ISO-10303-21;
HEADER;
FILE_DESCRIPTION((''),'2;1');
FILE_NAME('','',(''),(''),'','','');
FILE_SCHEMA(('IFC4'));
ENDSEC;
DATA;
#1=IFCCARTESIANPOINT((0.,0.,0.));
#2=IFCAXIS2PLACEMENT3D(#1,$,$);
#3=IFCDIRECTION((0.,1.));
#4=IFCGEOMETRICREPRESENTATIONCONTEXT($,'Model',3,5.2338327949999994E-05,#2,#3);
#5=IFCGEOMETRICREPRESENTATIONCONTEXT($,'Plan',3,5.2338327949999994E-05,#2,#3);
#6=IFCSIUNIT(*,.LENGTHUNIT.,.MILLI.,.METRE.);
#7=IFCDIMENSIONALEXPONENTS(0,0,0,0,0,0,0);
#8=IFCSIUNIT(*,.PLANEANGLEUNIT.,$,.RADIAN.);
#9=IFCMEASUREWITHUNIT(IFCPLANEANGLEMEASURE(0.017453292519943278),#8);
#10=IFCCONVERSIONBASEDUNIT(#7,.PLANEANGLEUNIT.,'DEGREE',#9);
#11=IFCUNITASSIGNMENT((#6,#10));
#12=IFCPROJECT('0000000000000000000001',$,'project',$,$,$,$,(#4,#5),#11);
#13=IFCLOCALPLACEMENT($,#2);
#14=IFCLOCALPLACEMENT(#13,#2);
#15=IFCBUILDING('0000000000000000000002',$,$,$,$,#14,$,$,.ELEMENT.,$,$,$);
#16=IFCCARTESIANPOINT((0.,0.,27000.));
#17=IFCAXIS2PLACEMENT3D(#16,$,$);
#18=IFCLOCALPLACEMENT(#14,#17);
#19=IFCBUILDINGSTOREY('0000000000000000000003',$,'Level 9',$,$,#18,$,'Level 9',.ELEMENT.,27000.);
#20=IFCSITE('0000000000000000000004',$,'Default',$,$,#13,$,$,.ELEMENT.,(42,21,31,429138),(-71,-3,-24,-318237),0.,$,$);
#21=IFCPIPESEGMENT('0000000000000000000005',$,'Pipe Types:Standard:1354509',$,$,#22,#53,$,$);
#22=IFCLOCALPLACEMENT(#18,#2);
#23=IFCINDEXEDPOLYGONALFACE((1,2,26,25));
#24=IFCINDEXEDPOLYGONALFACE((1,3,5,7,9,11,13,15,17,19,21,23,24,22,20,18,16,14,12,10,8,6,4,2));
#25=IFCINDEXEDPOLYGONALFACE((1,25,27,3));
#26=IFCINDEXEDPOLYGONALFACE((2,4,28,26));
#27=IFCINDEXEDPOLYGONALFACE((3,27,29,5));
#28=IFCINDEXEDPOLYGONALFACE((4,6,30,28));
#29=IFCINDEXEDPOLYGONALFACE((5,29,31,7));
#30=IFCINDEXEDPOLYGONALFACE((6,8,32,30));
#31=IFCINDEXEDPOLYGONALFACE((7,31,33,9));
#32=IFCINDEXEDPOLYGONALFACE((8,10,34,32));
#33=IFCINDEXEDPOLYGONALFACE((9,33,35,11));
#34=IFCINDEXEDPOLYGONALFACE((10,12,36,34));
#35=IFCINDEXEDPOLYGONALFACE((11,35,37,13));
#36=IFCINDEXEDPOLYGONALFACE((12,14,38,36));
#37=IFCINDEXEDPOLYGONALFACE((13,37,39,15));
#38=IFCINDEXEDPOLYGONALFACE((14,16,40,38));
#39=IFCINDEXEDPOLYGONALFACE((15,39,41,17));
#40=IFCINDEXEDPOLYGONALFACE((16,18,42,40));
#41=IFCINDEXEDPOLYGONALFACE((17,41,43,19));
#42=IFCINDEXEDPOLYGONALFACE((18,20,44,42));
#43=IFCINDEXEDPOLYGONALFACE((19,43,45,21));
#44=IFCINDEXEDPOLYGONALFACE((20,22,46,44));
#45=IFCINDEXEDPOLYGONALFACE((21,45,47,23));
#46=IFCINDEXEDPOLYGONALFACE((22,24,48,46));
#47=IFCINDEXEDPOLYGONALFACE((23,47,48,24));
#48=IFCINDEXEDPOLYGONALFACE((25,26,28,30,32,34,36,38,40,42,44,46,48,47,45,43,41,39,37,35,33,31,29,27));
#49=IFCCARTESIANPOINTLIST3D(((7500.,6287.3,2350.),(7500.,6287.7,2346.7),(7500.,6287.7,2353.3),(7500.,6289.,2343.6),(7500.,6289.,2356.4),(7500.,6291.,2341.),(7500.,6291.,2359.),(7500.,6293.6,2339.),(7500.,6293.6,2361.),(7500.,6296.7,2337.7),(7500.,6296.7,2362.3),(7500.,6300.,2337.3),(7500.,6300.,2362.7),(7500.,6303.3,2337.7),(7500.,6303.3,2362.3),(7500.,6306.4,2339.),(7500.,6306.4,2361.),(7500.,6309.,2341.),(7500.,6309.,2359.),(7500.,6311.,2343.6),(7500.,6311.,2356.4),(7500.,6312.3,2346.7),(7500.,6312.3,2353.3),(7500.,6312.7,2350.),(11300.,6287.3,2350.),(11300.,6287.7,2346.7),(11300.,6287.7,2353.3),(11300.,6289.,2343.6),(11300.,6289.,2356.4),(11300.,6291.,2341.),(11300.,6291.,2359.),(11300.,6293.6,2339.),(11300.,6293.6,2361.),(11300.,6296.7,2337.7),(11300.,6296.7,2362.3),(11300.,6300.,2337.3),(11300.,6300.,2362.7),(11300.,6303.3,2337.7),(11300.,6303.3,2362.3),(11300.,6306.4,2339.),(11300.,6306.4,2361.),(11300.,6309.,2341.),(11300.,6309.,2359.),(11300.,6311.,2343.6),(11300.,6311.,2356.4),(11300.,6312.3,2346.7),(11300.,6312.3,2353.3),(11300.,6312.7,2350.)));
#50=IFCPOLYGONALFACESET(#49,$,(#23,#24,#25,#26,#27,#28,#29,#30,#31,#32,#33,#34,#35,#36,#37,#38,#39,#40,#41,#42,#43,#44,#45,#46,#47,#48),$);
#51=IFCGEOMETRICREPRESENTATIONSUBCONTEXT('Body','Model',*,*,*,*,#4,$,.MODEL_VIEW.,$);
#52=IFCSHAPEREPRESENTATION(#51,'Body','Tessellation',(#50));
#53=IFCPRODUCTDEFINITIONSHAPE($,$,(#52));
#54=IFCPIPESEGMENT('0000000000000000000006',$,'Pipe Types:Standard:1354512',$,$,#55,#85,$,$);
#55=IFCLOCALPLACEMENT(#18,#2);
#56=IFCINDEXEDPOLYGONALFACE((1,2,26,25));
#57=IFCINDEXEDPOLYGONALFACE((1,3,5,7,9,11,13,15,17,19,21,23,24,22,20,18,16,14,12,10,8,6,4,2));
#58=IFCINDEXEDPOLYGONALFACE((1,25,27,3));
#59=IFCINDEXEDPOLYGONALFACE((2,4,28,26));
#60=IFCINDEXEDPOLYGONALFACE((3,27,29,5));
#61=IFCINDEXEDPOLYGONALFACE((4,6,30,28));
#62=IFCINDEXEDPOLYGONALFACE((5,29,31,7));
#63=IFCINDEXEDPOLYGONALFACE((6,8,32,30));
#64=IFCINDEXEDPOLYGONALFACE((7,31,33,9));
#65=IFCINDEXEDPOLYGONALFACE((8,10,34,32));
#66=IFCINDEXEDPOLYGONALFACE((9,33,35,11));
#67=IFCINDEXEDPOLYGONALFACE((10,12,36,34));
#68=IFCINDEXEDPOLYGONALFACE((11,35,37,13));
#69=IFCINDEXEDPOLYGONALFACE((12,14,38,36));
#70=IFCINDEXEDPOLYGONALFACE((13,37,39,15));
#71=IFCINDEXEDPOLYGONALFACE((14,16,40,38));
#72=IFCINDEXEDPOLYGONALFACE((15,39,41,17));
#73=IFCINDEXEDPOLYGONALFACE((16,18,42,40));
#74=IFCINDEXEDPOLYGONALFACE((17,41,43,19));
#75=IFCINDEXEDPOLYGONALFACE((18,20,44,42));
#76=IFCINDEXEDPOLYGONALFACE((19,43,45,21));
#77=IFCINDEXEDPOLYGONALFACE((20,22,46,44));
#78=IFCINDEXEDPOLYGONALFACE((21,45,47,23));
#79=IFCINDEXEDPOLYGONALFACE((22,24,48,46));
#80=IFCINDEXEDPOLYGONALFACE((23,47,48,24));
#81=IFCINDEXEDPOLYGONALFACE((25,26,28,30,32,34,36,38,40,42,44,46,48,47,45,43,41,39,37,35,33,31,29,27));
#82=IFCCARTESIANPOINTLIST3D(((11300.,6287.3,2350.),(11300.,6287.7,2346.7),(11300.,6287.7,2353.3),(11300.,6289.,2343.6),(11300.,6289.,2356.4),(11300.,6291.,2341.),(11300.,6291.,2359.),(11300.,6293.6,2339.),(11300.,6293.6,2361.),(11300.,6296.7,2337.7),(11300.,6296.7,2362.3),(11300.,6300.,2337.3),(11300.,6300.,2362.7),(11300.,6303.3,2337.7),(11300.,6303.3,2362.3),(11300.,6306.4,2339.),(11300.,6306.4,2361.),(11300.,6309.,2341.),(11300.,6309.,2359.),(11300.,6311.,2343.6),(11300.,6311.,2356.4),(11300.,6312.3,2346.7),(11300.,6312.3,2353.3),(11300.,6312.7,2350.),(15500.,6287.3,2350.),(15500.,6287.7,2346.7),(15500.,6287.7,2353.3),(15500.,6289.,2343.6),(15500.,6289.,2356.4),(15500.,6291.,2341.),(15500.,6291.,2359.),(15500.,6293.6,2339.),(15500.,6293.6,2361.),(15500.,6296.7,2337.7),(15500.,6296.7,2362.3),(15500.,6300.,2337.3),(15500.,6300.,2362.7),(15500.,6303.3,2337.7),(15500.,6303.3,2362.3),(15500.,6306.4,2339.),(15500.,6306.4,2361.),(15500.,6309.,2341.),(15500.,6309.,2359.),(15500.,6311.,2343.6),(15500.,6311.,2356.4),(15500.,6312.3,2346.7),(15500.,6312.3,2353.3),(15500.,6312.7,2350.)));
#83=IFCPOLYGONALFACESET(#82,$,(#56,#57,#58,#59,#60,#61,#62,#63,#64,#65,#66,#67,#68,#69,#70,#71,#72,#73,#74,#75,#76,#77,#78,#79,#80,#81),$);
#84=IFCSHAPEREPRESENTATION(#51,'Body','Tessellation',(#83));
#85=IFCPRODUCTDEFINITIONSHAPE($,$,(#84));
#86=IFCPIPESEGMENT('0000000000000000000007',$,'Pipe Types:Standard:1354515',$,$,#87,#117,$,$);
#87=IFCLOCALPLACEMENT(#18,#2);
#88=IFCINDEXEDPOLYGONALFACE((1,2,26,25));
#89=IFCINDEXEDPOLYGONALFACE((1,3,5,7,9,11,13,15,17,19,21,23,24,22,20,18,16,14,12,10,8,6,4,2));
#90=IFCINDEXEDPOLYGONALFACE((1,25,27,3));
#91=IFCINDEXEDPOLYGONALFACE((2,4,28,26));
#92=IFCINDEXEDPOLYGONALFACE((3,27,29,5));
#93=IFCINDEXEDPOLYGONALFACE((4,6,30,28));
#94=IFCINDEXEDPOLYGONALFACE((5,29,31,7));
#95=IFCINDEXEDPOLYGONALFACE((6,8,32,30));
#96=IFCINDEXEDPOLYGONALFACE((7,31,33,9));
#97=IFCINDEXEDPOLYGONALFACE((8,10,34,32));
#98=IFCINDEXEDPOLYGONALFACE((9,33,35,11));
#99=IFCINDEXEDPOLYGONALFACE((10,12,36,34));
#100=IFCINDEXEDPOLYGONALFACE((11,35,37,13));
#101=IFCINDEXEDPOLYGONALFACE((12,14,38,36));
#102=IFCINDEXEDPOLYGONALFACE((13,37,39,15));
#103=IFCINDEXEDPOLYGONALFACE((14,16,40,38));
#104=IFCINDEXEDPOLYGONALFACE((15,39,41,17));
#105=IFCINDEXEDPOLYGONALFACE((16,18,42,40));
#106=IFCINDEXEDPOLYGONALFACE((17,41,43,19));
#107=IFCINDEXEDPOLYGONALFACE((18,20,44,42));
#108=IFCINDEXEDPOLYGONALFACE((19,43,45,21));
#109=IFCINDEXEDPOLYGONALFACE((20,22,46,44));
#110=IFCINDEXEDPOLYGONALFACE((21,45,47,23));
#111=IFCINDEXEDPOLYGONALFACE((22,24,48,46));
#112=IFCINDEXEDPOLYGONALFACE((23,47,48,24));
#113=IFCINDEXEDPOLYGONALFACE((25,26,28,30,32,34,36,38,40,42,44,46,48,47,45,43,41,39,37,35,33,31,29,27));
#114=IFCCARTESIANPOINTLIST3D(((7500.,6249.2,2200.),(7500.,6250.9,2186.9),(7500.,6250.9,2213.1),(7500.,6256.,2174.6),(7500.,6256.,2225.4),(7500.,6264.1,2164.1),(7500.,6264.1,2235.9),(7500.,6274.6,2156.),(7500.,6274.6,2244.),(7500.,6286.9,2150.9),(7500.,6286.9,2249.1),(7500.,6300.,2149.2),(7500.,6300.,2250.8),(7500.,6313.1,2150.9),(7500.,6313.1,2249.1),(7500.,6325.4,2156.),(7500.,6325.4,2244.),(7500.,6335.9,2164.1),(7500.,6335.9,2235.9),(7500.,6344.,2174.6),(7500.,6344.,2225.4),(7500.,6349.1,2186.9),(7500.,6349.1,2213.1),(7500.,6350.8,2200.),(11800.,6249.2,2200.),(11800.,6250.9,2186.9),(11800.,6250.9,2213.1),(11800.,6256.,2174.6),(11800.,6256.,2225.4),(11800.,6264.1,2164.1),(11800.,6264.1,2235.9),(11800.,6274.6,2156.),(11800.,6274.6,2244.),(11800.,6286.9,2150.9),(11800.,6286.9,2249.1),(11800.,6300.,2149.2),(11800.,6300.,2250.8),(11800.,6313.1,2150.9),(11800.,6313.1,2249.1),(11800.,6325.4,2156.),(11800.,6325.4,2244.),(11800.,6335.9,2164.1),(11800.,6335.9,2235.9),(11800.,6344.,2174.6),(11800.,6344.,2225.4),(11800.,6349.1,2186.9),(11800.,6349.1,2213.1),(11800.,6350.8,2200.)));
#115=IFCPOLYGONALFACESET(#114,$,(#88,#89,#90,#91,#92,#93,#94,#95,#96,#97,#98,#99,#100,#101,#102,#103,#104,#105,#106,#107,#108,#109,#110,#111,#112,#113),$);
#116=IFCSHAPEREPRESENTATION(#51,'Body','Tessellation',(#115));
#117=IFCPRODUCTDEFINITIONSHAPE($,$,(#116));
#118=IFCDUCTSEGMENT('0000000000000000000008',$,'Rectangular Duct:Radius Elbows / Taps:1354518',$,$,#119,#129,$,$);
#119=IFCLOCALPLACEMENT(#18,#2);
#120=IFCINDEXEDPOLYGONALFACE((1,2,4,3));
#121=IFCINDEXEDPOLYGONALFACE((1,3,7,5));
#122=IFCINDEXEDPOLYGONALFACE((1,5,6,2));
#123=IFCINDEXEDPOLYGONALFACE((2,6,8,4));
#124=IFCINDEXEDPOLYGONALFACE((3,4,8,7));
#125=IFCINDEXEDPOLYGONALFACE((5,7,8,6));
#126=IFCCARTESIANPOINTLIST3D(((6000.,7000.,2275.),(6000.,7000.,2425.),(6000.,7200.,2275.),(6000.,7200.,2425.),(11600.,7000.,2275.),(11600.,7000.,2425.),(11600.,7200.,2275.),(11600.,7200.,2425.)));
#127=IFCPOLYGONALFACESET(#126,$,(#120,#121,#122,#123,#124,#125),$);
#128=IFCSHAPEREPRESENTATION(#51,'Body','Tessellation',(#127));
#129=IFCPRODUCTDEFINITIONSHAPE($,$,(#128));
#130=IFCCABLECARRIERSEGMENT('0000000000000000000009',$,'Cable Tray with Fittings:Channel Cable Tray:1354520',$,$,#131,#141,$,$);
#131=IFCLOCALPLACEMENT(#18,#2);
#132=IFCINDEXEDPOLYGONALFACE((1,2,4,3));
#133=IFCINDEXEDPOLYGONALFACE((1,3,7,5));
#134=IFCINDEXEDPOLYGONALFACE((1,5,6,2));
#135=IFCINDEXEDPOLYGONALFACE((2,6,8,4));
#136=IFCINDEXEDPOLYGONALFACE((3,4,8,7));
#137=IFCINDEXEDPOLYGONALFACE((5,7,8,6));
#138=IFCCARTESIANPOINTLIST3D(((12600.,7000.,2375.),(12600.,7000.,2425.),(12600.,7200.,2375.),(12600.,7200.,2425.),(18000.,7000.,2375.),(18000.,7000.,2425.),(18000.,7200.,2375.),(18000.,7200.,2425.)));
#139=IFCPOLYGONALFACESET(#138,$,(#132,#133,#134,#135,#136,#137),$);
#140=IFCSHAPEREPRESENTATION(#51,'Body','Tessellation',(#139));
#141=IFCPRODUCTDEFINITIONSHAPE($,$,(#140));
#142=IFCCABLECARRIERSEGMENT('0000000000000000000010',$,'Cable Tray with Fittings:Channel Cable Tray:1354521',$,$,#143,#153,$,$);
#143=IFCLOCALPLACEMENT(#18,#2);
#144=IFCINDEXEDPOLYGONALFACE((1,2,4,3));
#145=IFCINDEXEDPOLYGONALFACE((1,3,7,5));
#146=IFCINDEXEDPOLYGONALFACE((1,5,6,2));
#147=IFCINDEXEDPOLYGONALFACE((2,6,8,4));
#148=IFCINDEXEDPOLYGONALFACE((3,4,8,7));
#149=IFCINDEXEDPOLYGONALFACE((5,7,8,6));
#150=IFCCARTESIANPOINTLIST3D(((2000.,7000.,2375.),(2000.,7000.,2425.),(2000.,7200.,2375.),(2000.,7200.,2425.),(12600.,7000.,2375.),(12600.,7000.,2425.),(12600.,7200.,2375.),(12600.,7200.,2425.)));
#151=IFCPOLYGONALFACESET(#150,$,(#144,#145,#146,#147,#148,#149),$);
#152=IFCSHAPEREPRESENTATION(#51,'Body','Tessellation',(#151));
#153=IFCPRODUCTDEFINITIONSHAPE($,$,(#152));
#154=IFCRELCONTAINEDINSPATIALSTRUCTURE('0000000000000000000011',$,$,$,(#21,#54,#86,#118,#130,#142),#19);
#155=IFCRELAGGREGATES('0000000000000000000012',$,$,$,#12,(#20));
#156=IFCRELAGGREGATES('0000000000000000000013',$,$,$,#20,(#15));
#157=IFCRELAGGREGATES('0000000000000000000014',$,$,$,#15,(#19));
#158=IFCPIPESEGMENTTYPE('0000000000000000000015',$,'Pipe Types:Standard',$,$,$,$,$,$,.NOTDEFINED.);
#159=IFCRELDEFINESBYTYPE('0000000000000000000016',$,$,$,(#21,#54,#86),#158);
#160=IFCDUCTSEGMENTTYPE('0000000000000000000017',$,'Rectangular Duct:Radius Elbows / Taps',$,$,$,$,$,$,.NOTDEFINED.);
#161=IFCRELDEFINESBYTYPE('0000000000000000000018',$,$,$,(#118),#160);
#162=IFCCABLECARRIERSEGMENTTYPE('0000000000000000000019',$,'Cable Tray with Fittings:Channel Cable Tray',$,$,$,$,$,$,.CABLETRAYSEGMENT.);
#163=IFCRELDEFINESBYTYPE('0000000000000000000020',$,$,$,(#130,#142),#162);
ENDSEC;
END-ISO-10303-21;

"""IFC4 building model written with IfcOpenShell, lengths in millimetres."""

from ifc_helpers import new_model, entity, si_unit, converted_unit, direction, frame, origin, place, context, subcontext, project, spatial, arc, indexed_curve, outline, extrude, type_object, element, save


model = new_model("IFC4")

# Units and contexts
model_context = context("Model", 3, precision=5.2338327949999994e-05, world=origin(), true_north=direction((0.0, 1.0)))
plan_context = context("Plan", 3, precision=5.2338327949999994e-05, world=origin(), true_north=direction((0.0, 1.0)))
body_context = subcontext(model_context, "Body", "Model", "MODEL_VIEW")
ifc_project = project(units=[si_unit("LENGTHUNIT", "METRE", prefix="MILLI"), converted_unit("PLANEANGLEUNIT", "DEGREE", entity("IfcPlaneAngleMeasure", 0.017453292519943278), si_unit("PLANEANGLEUNIT", "RADIAN"), dimensions=[0, 0, 0, 0, 0, 0, 0])], contexts=[model_context, plan_context])

# Site, building, storey
site_placement = place(None, origin())
site = spatial("IfcSite", under=ifc_project, at=site_placement, Name="Default", CompositionType="ELEMENT", RefLatitude=(42, 21, 31, 429138), RefLongitude=(-71, -3, -24, -318237), RefElevation=0.0)
building_placement = place(site_placement, origin())
building = spatial("IfcBuilding", under=site, at=building_placement, CompositionType="ELEMENT")
storey_placement = place(building_placement, frame((0.0, 0.0, 27000.0)))
storey = spatial("IfcBuildingStorey", under=building, at=storey_placement, Name="Level 9", LongName="Level 9", CompositionType="ELEMENT", Elevation=27000.0)

# Pipe segments
pipe_segment_type = type_object("IfcPipeSegmentType", Name="Pipe Types:Standard", PredefinedType="NOTDEFINED")
pipe_segment_1_placement = place(storey_placement, origin())
element("IfcPipeSegment", 1, at=pipe_segment_1_placement, inside=storey, type_object=pipe_segment_type, Name="Pipe Types:Standard:1354509", context=body_context, shape_type="SweptSolid", body=[
    extrude(outline(indexed_curve([(12.7, 0.0), (9.0, 9.0), (0.0, 12.7), (-9.0, 9.0), (-12.7, 0.0), (-9.0, -9.0), (0.0, -12.7), (9.0, -9.0)], segments=[arc(1, 2, 3), arc(3, 4, 5), arc(5, 6, 7), arc(7, 8, 1)], self_intersect=False)), frame((7500.0, 6300.0, 2350.0), z_axis=(1.0, 0.0, 0.0), x_axis=(0.0, 1.0, 0.0)), (0.0, 0.0, 1.0), 3800.0),
])
pipe_segment_2_placement = place(storey_placement, origin())
element("IfcPipeSegment", 2, at=pipe_segment_2_placement, inside=storey, type_object=pipe_segment_type, Name="Pipe Types:Standard:1354512", context=body_context, shape_type="SweptSolid", body=[
    extrude(outline(indexed_curve([(12.7, 0.0), (9.0, 9.0), (0.0, 12.7), (-9.0, 9.0), (-12.7, 0.0), (-9.0, -9.0), (0.0, -12.7), (9.0, -9.0)], segments=[arc(1, 2, 3), arc(3, 4, 5), arc(5, 6, 7), arc(7, 8, 1)], self_intersect=False)), frame((11300.0, 6300.0, 2350.0), z_axis=(1.0, 0.0, 0.0), x_axis=(0.0, -1.0, 0.0)), (0.0, 0.0, 1.0), 4200.0),
])
pipe_segment_3_placement = place(storey_placement, origin())
element("IfcPipeSegment", 3, at=pipe_segment_3_placement, inside=storey, type_object=pipe_segment_type, Name="Pipe Types:Standard:1354515", context=body_context, shape_type="SweptSolid", body=[
    extrude(outline(indexed_curve([(50.8, 0.0), (35.9, 35.9), (0.0, 50.8), (-35.9, 35.9), (-50.8, 0.0), (-35.9, -35.9), (0.0, -50.8), (35.9, -35.9)], segments=[arc(1, 2, 3), arc(3, 4, 5), arc(5, 6, 7), arc(7, 8, 1)], self_intersect=False)), frame((7500.0, 6300.0, 2200.0), z_axis=(1.0, 0.0, 0.0), x_axis=(0.0, 1.0, 0.0)), (0.0, 0.0, 1.0), 4300.0),
])

# Duct segment
duct_segment_type = type_object("IfcDuctSegmentType", Name="Rectangular Duct:Radius Elbows / Taps", PredefinedType="NOTDEFINED")
duct_segment_placement = place(storey_placement, origin())
element("IfcDuctSegment", 4, at=duct_segment_placement, inside=storey, type_object=duct_segment_type, Name="Rectangular Duct:Radius Elbows / Taps:1354518", context=body_context, shape_type="SweptSolid", body=[
    extrude(outline(indexed_curve([(-2800.0, -100.0), (2800.0, -100.0), (2800.0, 100.0), (-2800.0, 100.0), (-2800.0, -100.0)], self_intersect=False)), frame((8800.0, 7100.0, 2275.0), z_axis=(0.0, 0.0, 1.0), x_axis=(-1.0, 0.0, 0.0)), (0.0, 0.0, 1.0), 150.0),
])

# Cable carrier segments
cable_carrier_segment_type = type_object("IfcCableCarrierSegmentType", Name="Cable Tray with Fittings:Channel Cable Tray", PredefinedType="CABLETRAYSEGMENT")
cable_carrier_segment_1_placement = place(storey_placement, origin())
element("IfcCableCarrierSegment", 5, at=cable_carrier_segment_1_placement, inside=storey, type_object=cable_carrier_segment_type, Name="Cable Tray with Fittings:Channel Cable Tray:1354520", context=body_context, shape_type="SweptSolid", body=[
    extrude(outline(indexed_curve([(-2700.0, -100.0), (2700.0, -100.0), (2700.0, 100.0), (-2700.0, 100.0), (-2700.0, -100.0)], self_intersect=False)), frame((15300.0, 7100.0, 2375.0)), (0.0, 0.0, 1.0), 50.0),
])
cable_carrier_segment_2_placement = place(storey_placement, origin())
element("IfcCableCarrierSegment", 6, at=cable_carrier_segment_2_placement, inside=storey, type_object=cable_carrier_segment_type, Name="Cable Tray with Fittings:Channel Cable Tray:1354521", context=body_context, shape_type="SweptSolid", body=[
    extrude(outline(indexed_curve([(-5300.0, -100.0), (5300.0, -100.0), (5300.0, 100.0), (-5300.0, 100.0), (-5300.0, -100.0)], self_intersect=False)), frame((7300.0, 7100.0, 2375.0), z_axis=(0.0, 0.0, 1.0), x_axis=(-1.0, 0.0, 0.0)), (0.0, 0.0, 1.0), 50.0),
])

save(model, "model.ifc")
